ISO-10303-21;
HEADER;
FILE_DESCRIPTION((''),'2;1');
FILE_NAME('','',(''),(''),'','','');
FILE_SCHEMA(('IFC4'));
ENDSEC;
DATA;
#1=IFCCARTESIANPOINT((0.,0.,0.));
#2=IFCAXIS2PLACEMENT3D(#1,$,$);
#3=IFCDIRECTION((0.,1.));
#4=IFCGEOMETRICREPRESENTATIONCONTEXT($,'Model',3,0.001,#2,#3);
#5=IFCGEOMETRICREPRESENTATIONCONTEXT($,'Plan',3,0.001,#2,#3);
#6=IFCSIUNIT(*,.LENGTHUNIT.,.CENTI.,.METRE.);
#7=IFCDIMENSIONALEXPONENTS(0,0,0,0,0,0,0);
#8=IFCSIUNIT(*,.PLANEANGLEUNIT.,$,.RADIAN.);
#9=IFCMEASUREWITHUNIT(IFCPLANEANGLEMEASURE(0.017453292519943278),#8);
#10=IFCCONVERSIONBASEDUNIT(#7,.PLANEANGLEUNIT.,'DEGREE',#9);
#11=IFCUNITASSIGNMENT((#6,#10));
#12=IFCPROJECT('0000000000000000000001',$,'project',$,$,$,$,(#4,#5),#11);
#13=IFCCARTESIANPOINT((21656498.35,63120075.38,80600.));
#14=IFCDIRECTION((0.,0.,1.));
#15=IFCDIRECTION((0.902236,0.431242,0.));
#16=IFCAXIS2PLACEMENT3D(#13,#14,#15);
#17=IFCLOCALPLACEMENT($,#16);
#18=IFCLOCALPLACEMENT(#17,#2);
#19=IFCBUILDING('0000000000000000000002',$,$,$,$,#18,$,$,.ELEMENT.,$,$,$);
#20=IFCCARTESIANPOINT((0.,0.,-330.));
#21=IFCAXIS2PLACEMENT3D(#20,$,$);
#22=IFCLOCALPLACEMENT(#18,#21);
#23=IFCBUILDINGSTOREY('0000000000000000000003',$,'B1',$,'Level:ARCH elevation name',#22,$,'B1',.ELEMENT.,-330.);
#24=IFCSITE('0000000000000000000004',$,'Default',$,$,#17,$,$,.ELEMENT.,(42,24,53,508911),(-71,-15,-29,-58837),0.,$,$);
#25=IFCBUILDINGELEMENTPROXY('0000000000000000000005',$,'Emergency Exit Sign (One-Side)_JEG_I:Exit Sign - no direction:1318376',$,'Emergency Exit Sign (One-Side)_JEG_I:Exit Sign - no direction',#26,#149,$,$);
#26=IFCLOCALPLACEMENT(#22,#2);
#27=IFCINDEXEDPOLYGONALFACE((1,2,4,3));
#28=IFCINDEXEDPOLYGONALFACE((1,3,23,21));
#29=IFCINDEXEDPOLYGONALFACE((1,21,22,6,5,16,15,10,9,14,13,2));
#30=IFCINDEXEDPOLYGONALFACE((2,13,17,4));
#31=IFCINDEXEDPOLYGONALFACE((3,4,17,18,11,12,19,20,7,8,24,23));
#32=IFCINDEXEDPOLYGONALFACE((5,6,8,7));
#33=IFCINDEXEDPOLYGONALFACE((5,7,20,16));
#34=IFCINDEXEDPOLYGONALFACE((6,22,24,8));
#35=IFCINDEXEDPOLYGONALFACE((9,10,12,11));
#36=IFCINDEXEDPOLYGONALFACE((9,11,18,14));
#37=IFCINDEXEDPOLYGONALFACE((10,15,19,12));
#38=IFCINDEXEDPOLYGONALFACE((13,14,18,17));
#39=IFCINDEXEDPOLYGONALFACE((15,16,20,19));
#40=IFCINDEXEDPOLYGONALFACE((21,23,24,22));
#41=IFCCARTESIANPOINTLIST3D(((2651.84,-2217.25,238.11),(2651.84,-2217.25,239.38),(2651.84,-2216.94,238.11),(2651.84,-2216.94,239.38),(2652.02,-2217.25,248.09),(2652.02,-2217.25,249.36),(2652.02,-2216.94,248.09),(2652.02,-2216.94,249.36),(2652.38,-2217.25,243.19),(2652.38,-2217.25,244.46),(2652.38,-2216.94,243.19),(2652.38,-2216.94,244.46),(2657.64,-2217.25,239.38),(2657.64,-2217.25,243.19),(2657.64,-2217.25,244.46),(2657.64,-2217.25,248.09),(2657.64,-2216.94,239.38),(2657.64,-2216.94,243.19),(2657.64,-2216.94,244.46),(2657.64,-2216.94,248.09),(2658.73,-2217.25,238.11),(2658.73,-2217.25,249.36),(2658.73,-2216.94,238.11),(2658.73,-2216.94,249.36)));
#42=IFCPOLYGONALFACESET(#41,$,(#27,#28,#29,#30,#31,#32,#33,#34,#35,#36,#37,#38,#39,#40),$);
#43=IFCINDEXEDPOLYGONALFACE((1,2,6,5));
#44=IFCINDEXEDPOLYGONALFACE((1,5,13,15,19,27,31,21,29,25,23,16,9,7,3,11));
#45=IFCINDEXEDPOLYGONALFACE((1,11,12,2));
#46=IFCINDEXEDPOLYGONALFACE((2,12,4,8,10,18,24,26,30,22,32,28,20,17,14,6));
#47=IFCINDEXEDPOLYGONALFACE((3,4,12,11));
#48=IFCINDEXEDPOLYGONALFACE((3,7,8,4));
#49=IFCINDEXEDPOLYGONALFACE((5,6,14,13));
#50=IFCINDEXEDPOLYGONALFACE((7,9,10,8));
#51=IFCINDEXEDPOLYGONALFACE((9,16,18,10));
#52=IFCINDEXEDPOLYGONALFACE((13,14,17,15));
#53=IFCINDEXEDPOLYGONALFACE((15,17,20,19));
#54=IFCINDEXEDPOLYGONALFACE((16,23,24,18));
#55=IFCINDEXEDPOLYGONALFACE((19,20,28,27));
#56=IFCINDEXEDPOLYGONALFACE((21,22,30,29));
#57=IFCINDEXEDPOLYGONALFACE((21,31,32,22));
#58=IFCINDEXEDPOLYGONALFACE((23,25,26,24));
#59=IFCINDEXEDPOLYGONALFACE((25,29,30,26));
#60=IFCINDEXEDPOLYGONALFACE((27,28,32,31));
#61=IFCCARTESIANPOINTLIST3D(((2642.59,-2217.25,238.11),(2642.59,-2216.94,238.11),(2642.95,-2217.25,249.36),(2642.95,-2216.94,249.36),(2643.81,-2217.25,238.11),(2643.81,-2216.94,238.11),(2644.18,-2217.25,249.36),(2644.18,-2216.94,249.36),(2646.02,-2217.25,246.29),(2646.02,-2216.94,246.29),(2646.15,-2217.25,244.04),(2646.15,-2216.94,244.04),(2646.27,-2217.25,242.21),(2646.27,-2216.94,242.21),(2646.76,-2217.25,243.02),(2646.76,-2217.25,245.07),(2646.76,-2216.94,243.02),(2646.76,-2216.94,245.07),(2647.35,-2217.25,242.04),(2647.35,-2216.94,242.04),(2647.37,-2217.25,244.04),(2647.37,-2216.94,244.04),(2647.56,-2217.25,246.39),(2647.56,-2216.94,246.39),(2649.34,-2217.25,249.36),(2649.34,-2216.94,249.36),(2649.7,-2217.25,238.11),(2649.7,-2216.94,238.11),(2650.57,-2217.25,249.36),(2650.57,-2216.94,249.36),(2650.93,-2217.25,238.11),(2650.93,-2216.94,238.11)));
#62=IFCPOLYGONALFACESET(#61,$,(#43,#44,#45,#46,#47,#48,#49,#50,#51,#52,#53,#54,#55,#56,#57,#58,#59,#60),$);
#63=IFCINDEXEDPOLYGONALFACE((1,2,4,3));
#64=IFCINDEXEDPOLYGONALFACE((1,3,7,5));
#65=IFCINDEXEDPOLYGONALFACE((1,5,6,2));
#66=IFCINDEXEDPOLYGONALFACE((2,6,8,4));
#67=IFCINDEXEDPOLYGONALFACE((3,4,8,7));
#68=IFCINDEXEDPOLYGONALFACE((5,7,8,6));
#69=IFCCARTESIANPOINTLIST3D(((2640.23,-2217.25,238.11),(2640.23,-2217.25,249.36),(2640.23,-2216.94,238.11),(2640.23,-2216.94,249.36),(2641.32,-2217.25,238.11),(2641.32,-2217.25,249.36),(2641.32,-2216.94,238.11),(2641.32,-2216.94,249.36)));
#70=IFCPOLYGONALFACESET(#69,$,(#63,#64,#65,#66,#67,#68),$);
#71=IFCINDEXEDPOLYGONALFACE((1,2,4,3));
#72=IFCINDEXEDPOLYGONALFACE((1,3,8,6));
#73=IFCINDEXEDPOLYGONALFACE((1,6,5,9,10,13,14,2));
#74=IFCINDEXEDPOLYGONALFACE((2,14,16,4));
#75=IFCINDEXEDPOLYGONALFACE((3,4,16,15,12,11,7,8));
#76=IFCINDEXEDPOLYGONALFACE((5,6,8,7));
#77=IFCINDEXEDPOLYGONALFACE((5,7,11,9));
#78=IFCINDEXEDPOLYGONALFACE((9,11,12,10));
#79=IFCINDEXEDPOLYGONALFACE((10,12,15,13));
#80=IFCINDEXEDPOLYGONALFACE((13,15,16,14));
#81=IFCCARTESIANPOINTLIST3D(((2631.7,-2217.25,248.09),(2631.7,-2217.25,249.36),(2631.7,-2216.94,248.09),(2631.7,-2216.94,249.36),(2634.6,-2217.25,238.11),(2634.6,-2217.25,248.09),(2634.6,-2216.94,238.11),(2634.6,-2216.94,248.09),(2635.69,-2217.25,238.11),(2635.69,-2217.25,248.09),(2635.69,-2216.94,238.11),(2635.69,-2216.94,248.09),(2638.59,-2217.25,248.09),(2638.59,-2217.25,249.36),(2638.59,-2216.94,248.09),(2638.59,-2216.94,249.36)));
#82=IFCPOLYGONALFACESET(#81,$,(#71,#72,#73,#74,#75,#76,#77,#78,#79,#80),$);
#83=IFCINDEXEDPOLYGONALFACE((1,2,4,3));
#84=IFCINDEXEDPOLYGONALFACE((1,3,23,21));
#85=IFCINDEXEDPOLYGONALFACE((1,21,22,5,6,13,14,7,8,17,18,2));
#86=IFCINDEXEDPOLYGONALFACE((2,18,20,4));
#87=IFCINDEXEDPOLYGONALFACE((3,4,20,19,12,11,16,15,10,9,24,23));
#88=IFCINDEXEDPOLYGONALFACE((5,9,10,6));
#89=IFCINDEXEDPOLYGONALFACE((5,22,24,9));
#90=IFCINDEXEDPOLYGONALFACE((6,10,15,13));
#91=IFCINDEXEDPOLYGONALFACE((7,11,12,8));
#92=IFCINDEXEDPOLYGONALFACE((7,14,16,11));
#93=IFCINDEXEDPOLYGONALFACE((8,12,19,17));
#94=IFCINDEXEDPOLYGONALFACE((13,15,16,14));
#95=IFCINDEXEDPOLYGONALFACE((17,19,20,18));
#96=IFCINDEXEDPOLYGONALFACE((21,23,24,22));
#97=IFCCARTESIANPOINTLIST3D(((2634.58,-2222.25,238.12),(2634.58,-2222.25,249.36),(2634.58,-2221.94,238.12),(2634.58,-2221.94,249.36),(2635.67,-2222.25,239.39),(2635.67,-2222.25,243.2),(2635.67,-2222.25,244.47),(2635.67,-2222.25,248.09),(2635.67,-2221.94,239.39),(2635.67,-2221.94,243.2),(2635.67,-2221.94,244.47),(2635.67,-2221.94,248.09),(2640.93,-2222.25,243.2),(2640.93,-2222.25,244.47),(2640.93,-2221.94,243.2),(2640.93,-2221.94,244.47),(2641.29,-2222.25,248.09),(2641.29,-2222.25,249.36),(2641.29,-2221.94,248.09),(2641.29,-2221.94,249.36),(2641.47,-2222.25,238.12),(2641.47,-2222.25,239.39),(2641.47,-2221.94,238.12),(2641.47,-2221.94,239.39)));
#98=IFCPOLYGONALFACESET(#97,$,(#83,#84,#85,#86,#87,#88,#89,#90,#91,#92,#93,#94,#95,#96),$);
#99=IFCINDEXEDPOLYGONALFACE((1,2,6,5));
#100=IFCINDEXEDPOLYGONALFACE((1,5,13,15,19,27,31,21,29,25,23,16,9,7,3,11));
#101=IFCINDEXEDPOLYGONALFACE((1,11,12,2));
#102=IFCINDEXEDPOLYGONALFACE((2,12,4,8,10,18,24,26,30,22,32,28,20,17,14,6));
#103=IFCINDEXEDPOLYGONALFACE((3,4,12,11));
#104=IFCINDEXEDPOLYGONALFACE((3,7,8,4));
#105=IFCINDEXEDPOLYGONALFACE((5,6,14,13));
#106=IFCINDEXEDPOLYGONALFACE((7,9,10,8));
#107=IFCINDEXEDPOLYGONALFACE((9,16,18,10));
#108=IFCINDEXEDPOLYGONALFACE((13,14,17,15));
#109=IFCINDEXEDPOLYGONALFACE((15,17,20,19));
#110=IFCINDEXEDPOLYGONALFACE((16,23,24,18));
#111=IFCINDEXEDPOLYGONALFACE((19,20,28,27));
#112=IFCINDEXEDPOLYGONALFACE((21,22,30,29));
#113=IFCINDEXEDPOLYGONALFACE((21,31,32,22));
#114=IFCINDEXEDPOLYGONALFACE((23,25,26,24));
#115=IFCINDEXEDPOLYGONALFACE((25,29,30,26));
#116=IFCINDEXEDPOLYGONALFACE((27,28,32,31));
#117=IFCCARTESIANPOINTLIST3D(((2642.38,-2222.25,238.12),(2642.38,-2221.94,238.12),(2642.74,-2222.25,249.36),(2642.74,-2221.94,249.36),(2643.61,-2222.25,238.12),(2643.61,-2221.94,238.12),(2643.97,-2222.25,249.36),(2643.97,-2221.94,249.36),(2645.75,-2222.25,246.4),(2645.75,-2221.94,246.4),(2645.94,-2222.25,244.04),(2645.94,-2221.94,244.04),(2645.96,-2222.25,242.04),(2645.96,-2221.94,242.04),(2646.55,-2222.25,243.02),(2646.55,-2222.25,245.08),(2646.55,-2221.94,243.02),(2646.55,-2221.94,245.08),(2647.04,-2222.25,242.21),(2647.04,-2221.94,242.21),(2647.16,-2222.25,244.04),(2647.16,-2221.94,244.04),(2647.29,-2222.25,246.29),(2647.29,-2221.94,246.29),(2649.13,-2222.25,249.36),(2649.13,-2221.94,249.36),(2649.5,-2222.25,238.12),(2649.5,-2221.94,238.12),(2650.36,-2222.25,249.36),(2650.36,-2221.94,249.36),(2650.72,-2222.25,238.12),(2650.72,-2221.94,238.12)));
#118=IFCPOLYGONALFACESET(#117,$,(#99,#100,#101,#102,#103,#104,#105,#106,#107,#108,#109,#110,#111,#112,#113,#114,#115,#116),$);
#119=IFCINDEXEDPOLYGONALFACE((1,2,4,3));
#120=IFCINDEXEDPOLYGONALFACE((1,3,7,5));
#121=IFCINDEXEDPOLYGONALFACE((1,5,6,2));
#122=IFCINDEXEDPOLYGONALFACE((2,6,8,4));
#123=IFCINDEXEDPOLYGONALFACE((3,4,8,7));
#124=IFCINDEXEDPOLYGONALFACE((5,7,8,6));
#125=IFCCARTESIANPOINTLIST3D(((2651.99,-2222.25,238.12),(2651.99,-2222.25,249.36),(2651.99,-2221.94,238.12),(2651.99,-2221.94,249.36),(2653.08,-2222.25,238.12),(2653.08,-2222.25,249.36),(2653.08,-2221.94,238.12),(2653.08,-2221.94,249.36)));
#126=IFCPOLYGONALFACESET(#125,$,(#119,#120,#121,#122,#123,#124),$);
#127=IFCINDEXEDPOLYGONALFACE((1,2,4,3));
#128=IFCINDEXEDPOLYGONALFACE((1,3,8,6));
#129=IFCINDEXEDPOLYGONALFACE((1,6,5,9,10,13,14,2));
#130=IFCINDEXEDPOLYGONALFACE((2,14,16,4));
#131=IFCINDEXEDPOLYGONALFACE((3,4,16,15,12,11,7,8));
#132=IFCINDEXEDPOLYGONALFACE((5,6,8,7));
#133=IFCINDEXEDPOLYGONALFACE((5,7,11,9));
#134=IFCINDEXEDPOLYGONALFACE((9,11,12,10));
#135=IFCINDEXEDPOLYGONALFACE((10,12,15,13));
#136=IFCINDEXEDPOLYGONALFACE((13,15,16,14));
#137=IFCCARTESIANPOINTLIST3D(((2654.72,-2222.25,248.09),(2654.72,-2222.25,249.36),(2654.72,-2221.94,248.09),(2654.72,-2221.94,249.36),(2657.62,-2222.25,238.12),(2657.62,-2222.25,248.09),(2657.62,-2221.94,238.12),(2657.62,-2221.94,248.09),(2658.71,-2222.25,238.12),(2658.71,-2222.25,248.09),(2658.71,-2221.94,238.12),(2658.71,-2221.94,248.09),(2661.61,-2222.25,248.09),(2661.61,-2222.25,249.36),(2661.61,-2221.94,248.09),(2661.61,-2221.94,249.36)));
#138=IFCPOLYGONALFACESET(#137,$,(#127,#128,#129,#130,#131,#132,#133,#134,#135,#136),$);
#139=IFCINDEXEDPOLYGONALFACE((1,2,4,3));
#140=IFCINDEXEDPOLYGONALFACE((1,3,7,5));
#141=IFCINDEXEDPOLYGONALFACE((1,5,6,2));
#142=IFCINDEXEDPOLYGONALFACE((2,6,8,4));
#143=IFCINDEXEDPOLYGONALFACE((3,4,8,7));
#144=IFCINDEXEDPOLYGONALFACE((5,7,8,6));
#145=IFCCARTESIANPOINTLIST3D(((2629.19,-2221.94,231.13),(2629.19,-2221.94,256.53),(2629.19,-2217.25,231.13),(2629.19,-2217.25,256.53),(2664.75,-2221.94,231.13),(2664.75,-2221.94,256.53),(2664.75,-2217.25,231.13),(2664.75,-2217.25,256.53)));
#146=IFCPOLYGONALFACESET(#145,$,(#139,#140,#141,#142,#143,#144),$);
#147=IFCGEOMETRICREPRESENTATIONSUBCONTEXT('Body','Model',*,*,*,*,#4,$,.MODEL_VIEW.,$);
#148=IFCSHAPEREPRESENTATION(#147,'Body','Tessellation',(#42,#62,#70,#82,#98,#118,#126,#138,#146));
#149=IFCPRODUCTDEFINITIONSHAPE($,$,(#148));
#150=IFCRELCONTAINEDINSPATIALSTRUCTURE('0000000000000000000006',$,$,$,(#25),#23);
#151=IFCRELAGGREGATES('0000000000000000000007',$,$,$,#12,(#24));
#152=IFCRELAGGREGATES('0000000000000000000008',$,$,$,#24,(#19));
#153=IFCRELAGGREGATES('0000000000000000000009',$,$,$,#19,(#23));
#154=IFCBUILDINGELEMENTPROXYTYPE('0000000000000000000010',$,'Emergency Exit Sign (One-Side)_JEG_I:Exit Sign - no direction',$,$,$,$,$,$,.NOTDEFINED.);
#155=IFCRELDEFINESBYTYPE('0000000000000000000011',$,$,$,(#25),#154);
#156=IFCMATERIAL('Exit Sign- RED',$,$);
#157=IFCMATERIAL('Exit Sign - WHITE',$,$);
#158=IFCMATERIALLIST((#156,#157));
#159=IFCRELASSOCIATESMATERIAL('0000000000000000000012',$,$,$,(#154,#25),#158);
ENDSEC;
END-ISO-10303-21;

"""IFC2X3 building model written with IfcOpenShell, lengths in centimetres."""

from ifc_helpers import new_model, entity, si_unit, converted_unit, direction, frame, frame_2d, origin, origin_2d_with_axis, place, context, subcontext, project, spatial, polyline, rectangle, outline, extrude, source, transform, mapped, material, material_list, type_object, type_shapes, element, save


model = new_model("IFC2X3")

# Units and contexts
model_context = context("Model", 3, precision=0.001, world=origin(), true_north=direction((0.0, 1.0)))
plan_context = context("Plan", 3, precision=0.001, world=origin(), true_north=direction((0.0, 1.0)))
body_context = subcontext(model_context, "Body", "Model", "MODEL_VIEW")
ifc_project = project(units=[si_unit("LENGTHUNIT", "METRE", prefix="CENTI"), converted_unit("PLANEANGLEUNIT", "DEGREE", entity("IfcPlaneAngleMeasure", 0.017453292519943278), si_unit("PLANEANGLEUNIT", "RADIAN"), dimensions=[0, 0, 0, 0, 0, 0, 0])], contexts=[model_context, plan_context])

# Site, building, storey
site_placement = place(None, frame((21656498.35, 63120075.38, 80600.0), z_axis=(0.0, 0.0, 1.0), x_axis=(0.902236, 0.431242, 0.0)))
site = spatial("IfcSite", under=ifc_project, at=site_placement, Name="Default", CompositionType="ELEMENT", RefLatitude=(42, 24, 53, 508911), RefLongitude=(-71, -15, -29, -58837), RefElevation=0.0)
building_placement = place(site_placement, origin())
building = spatial("IfcBuilding", under=site, at=building_placement, CompositionType="ELEMENT")
storey_placement = place(building_placement, frame((0.0, 0.0, -330.0)))
storey = spatial("IfcBuildingStorey", under=building, at=storey_placement, Name="B1", ObjectType="Level:ARCH elevation name", LongName="B1", CompositionType="ELEMENT", Elevation=-330.0)

# Shared definitions
ifc_material_1 = material(Name="Exit Sign - WHITE")
ifc_material_2 = material(Name="Exit Sign- RED")

# Building element proxy
ifc_material_list_1 = material_list([ifc_material_2, ifc_material_1])
building_element_proxy_type_1 = type_object("IfcBuildingElementProxyType", Name="Emergency Exit Sign (One-Side)_JEG_I:Exit Sign - no direction", PredefinedType="NOTDEFINED", material=ifc_material_list_1)
shared_shape_1 = source(origin(), body_context, "Body", "SweptSolid", [
    extrude(outline(polyline([(-5.65, -3.69), (5.59, -3.69), (5.59, 3.02), (4.32, 3.02), (4.32, -2.6), (0.7, -2.6), (0.7, 2.66), (-0.57, 2.66), (-0.57, -2.6), (-4.38, -2.6), (-4.38, 3.21), (-5.65, 3.21), (-5.65, -3.69)])), frame((-8.08, -5.22, 12.64), z_axis=(0.0, 1.0, 0.0), x_axis=(0.0, 0.0, 1.0)), (0.0, 0.0, 1.0), 0.32),
    extrude(outline(polyline([(-7.14, 0.57), (-6.5, -0.49), (-1.93, -0.48), (-0.78, -0.48), (-1.23, -1.32), (-3.47, -5.53), (-2.84, -6.59), (0.41, -0.48), (6.62, -0.48), (5.99, 0.57), (2.4, 0.57), (0.98, 0.58), (1.7, 1.94), (3.32, 5.0), (2.69, 6.05), (-0.22, 0.57), (-7.14, 0.57)])), frame((0.2, -5.22, 12.81), z_axis=(0.0, -1.0, 0.0), x_axis=(0.515099, 0.0, 0.857131)), (0.0, 0.0, -1.0), 0.32),
    extrude(rectangle(XDim=0.32, YDim=1.09, at=frame_2d((0.0, 0.0), x_axis=(1.0, 0.0))), frame((6.19, -5.06, 6.99), z_axis=(0.0, 0.0, 1.0), x_axis=(0.0, 1.0, 0.0)), (0.0, 0.0, 1.0), 11.25),
    extrude(outline(polyline([(-7.8, 0.54), (-7.8, -0.54), (2.18, -0.54), (2.18, -3.45), (3.45, -3.45), (3.45, 3.45), (2.18, 3.45), (2.18, 0.54), (-7.8, 0.54)])), frame((11.82, -5.22, 14.79), z_axis=(0.0, -1.0, 0.0), x_axis=(0.0, 0.0, 1.0)), (0.0, 0.0, -1.0), 0.32),
    extrude(outline(polyline([(-3.69, -5.65), (3.21, -5.65), (3.21, -4.38), (-2.6, -4.38), (-2.6, -0.57), (2.66, -0.57), (2.66, 0.7), (-2.6, 0.7), (-2.6, 4.32), (3.02, 4.32), (3.02, 5.59), (-3.69, 5.59), (-3.69, -5.65)])), frame((8.7, -0.22, 12.65), z_axis=(0.0, 1.0, 0.0), x_axis=(-1.0, 0.0, 0.0)), (0.0, 0.0, 1.0), 0.32),
    extrude(outline(polyline([(-4.16, -5.82), (-2.93, -5.82), (-0.58, -1.9), (0.01, -0.92), (0.5, -1.73), (2.96, -5.82), (4.18, -5.82), (0.62, 0.1), (3.82, 5.42), (2.59, 5.42), (0.75, 2.35), (0.01, 1.14), (-0.79, 2.46), (-2.57, 5.42), (-3.8, 5.42), (-0.6, 0.1), (-4.16, -5.82)])), frame((0.43, -0.22, 12.82), z_axis=(0.0, 1.0, 0.0), x_axis=(-1.0, 0.0, 0.0)), (0.0, 0.0, 1.0), 0.32),
    extrude(rectangle(XDim=0.32, YDim=1.09, at=origin_2d_with_axis()), frame((-5.57, -0.06, 6.99), z_axis=(0.0, 0.0, 1.0), x_axis=(0.0, -1.0, 0.0)), (0.0, 0.0, 1.0), 11.25),
    extrude(outline(polyline([(-0.54, -7.8), (0.54, -7.8), (0.54, 2.18), (3.45, 2.18), (3.45, 3.45), (-3.45, 3.45), (-3.45, 2.18), (-0.54, 2.18), (-0.54, -7.8)])), frame((-11.2, -0.22, 14.79), z_axis=(0.0, 1.0, 0.0), x_axis=(-1.0, 0.0, 0.0)), (0.0, 0.0, 1.0), 0.32),
    extrude(rectangle(XDim=4.68, YDim=35.56, at=origin_2d_with_axis()), frame((0.0, -2.56, 0.01), z_axis=(0.0, 0.0, 1.0), x_axis=(0.0, 1.0, 0.0)), (0.0, 0.0, 1.0), 25.4),
])
type_shapes(building_element_proxy_type_1, [shared_shape_1])
for number, where, z_axis, x_axis, name in (
    (1, (2646.97, -2222.16, 231.12), (0.0, 0.0, 1.0), (-1.0, 0.0, 0.0), "Emergency Exit Sign (One-Side)_JEG_I:Exit Sign - no direction:1318376"),
):
    element("IfcBuildingElementProxy", number, at=place(storey_placement, frame(where, z_axis=z_axis, x_axis=x_axis)), inside=storey, type_object=building_element_proxy_type_1, material=ifc_material_list_1, Name=name, ObjectType="Emergency Exit Sign (One-Side)_JEG_I:Exit Sign - no direction", context=body_context, shape_type="MappedRepresentation", body=[
        mapped(shared_shape_1, transform((0.0, 0.0, 0.0), scale=1.0)),
    ])

save(model, "model.ifc")
